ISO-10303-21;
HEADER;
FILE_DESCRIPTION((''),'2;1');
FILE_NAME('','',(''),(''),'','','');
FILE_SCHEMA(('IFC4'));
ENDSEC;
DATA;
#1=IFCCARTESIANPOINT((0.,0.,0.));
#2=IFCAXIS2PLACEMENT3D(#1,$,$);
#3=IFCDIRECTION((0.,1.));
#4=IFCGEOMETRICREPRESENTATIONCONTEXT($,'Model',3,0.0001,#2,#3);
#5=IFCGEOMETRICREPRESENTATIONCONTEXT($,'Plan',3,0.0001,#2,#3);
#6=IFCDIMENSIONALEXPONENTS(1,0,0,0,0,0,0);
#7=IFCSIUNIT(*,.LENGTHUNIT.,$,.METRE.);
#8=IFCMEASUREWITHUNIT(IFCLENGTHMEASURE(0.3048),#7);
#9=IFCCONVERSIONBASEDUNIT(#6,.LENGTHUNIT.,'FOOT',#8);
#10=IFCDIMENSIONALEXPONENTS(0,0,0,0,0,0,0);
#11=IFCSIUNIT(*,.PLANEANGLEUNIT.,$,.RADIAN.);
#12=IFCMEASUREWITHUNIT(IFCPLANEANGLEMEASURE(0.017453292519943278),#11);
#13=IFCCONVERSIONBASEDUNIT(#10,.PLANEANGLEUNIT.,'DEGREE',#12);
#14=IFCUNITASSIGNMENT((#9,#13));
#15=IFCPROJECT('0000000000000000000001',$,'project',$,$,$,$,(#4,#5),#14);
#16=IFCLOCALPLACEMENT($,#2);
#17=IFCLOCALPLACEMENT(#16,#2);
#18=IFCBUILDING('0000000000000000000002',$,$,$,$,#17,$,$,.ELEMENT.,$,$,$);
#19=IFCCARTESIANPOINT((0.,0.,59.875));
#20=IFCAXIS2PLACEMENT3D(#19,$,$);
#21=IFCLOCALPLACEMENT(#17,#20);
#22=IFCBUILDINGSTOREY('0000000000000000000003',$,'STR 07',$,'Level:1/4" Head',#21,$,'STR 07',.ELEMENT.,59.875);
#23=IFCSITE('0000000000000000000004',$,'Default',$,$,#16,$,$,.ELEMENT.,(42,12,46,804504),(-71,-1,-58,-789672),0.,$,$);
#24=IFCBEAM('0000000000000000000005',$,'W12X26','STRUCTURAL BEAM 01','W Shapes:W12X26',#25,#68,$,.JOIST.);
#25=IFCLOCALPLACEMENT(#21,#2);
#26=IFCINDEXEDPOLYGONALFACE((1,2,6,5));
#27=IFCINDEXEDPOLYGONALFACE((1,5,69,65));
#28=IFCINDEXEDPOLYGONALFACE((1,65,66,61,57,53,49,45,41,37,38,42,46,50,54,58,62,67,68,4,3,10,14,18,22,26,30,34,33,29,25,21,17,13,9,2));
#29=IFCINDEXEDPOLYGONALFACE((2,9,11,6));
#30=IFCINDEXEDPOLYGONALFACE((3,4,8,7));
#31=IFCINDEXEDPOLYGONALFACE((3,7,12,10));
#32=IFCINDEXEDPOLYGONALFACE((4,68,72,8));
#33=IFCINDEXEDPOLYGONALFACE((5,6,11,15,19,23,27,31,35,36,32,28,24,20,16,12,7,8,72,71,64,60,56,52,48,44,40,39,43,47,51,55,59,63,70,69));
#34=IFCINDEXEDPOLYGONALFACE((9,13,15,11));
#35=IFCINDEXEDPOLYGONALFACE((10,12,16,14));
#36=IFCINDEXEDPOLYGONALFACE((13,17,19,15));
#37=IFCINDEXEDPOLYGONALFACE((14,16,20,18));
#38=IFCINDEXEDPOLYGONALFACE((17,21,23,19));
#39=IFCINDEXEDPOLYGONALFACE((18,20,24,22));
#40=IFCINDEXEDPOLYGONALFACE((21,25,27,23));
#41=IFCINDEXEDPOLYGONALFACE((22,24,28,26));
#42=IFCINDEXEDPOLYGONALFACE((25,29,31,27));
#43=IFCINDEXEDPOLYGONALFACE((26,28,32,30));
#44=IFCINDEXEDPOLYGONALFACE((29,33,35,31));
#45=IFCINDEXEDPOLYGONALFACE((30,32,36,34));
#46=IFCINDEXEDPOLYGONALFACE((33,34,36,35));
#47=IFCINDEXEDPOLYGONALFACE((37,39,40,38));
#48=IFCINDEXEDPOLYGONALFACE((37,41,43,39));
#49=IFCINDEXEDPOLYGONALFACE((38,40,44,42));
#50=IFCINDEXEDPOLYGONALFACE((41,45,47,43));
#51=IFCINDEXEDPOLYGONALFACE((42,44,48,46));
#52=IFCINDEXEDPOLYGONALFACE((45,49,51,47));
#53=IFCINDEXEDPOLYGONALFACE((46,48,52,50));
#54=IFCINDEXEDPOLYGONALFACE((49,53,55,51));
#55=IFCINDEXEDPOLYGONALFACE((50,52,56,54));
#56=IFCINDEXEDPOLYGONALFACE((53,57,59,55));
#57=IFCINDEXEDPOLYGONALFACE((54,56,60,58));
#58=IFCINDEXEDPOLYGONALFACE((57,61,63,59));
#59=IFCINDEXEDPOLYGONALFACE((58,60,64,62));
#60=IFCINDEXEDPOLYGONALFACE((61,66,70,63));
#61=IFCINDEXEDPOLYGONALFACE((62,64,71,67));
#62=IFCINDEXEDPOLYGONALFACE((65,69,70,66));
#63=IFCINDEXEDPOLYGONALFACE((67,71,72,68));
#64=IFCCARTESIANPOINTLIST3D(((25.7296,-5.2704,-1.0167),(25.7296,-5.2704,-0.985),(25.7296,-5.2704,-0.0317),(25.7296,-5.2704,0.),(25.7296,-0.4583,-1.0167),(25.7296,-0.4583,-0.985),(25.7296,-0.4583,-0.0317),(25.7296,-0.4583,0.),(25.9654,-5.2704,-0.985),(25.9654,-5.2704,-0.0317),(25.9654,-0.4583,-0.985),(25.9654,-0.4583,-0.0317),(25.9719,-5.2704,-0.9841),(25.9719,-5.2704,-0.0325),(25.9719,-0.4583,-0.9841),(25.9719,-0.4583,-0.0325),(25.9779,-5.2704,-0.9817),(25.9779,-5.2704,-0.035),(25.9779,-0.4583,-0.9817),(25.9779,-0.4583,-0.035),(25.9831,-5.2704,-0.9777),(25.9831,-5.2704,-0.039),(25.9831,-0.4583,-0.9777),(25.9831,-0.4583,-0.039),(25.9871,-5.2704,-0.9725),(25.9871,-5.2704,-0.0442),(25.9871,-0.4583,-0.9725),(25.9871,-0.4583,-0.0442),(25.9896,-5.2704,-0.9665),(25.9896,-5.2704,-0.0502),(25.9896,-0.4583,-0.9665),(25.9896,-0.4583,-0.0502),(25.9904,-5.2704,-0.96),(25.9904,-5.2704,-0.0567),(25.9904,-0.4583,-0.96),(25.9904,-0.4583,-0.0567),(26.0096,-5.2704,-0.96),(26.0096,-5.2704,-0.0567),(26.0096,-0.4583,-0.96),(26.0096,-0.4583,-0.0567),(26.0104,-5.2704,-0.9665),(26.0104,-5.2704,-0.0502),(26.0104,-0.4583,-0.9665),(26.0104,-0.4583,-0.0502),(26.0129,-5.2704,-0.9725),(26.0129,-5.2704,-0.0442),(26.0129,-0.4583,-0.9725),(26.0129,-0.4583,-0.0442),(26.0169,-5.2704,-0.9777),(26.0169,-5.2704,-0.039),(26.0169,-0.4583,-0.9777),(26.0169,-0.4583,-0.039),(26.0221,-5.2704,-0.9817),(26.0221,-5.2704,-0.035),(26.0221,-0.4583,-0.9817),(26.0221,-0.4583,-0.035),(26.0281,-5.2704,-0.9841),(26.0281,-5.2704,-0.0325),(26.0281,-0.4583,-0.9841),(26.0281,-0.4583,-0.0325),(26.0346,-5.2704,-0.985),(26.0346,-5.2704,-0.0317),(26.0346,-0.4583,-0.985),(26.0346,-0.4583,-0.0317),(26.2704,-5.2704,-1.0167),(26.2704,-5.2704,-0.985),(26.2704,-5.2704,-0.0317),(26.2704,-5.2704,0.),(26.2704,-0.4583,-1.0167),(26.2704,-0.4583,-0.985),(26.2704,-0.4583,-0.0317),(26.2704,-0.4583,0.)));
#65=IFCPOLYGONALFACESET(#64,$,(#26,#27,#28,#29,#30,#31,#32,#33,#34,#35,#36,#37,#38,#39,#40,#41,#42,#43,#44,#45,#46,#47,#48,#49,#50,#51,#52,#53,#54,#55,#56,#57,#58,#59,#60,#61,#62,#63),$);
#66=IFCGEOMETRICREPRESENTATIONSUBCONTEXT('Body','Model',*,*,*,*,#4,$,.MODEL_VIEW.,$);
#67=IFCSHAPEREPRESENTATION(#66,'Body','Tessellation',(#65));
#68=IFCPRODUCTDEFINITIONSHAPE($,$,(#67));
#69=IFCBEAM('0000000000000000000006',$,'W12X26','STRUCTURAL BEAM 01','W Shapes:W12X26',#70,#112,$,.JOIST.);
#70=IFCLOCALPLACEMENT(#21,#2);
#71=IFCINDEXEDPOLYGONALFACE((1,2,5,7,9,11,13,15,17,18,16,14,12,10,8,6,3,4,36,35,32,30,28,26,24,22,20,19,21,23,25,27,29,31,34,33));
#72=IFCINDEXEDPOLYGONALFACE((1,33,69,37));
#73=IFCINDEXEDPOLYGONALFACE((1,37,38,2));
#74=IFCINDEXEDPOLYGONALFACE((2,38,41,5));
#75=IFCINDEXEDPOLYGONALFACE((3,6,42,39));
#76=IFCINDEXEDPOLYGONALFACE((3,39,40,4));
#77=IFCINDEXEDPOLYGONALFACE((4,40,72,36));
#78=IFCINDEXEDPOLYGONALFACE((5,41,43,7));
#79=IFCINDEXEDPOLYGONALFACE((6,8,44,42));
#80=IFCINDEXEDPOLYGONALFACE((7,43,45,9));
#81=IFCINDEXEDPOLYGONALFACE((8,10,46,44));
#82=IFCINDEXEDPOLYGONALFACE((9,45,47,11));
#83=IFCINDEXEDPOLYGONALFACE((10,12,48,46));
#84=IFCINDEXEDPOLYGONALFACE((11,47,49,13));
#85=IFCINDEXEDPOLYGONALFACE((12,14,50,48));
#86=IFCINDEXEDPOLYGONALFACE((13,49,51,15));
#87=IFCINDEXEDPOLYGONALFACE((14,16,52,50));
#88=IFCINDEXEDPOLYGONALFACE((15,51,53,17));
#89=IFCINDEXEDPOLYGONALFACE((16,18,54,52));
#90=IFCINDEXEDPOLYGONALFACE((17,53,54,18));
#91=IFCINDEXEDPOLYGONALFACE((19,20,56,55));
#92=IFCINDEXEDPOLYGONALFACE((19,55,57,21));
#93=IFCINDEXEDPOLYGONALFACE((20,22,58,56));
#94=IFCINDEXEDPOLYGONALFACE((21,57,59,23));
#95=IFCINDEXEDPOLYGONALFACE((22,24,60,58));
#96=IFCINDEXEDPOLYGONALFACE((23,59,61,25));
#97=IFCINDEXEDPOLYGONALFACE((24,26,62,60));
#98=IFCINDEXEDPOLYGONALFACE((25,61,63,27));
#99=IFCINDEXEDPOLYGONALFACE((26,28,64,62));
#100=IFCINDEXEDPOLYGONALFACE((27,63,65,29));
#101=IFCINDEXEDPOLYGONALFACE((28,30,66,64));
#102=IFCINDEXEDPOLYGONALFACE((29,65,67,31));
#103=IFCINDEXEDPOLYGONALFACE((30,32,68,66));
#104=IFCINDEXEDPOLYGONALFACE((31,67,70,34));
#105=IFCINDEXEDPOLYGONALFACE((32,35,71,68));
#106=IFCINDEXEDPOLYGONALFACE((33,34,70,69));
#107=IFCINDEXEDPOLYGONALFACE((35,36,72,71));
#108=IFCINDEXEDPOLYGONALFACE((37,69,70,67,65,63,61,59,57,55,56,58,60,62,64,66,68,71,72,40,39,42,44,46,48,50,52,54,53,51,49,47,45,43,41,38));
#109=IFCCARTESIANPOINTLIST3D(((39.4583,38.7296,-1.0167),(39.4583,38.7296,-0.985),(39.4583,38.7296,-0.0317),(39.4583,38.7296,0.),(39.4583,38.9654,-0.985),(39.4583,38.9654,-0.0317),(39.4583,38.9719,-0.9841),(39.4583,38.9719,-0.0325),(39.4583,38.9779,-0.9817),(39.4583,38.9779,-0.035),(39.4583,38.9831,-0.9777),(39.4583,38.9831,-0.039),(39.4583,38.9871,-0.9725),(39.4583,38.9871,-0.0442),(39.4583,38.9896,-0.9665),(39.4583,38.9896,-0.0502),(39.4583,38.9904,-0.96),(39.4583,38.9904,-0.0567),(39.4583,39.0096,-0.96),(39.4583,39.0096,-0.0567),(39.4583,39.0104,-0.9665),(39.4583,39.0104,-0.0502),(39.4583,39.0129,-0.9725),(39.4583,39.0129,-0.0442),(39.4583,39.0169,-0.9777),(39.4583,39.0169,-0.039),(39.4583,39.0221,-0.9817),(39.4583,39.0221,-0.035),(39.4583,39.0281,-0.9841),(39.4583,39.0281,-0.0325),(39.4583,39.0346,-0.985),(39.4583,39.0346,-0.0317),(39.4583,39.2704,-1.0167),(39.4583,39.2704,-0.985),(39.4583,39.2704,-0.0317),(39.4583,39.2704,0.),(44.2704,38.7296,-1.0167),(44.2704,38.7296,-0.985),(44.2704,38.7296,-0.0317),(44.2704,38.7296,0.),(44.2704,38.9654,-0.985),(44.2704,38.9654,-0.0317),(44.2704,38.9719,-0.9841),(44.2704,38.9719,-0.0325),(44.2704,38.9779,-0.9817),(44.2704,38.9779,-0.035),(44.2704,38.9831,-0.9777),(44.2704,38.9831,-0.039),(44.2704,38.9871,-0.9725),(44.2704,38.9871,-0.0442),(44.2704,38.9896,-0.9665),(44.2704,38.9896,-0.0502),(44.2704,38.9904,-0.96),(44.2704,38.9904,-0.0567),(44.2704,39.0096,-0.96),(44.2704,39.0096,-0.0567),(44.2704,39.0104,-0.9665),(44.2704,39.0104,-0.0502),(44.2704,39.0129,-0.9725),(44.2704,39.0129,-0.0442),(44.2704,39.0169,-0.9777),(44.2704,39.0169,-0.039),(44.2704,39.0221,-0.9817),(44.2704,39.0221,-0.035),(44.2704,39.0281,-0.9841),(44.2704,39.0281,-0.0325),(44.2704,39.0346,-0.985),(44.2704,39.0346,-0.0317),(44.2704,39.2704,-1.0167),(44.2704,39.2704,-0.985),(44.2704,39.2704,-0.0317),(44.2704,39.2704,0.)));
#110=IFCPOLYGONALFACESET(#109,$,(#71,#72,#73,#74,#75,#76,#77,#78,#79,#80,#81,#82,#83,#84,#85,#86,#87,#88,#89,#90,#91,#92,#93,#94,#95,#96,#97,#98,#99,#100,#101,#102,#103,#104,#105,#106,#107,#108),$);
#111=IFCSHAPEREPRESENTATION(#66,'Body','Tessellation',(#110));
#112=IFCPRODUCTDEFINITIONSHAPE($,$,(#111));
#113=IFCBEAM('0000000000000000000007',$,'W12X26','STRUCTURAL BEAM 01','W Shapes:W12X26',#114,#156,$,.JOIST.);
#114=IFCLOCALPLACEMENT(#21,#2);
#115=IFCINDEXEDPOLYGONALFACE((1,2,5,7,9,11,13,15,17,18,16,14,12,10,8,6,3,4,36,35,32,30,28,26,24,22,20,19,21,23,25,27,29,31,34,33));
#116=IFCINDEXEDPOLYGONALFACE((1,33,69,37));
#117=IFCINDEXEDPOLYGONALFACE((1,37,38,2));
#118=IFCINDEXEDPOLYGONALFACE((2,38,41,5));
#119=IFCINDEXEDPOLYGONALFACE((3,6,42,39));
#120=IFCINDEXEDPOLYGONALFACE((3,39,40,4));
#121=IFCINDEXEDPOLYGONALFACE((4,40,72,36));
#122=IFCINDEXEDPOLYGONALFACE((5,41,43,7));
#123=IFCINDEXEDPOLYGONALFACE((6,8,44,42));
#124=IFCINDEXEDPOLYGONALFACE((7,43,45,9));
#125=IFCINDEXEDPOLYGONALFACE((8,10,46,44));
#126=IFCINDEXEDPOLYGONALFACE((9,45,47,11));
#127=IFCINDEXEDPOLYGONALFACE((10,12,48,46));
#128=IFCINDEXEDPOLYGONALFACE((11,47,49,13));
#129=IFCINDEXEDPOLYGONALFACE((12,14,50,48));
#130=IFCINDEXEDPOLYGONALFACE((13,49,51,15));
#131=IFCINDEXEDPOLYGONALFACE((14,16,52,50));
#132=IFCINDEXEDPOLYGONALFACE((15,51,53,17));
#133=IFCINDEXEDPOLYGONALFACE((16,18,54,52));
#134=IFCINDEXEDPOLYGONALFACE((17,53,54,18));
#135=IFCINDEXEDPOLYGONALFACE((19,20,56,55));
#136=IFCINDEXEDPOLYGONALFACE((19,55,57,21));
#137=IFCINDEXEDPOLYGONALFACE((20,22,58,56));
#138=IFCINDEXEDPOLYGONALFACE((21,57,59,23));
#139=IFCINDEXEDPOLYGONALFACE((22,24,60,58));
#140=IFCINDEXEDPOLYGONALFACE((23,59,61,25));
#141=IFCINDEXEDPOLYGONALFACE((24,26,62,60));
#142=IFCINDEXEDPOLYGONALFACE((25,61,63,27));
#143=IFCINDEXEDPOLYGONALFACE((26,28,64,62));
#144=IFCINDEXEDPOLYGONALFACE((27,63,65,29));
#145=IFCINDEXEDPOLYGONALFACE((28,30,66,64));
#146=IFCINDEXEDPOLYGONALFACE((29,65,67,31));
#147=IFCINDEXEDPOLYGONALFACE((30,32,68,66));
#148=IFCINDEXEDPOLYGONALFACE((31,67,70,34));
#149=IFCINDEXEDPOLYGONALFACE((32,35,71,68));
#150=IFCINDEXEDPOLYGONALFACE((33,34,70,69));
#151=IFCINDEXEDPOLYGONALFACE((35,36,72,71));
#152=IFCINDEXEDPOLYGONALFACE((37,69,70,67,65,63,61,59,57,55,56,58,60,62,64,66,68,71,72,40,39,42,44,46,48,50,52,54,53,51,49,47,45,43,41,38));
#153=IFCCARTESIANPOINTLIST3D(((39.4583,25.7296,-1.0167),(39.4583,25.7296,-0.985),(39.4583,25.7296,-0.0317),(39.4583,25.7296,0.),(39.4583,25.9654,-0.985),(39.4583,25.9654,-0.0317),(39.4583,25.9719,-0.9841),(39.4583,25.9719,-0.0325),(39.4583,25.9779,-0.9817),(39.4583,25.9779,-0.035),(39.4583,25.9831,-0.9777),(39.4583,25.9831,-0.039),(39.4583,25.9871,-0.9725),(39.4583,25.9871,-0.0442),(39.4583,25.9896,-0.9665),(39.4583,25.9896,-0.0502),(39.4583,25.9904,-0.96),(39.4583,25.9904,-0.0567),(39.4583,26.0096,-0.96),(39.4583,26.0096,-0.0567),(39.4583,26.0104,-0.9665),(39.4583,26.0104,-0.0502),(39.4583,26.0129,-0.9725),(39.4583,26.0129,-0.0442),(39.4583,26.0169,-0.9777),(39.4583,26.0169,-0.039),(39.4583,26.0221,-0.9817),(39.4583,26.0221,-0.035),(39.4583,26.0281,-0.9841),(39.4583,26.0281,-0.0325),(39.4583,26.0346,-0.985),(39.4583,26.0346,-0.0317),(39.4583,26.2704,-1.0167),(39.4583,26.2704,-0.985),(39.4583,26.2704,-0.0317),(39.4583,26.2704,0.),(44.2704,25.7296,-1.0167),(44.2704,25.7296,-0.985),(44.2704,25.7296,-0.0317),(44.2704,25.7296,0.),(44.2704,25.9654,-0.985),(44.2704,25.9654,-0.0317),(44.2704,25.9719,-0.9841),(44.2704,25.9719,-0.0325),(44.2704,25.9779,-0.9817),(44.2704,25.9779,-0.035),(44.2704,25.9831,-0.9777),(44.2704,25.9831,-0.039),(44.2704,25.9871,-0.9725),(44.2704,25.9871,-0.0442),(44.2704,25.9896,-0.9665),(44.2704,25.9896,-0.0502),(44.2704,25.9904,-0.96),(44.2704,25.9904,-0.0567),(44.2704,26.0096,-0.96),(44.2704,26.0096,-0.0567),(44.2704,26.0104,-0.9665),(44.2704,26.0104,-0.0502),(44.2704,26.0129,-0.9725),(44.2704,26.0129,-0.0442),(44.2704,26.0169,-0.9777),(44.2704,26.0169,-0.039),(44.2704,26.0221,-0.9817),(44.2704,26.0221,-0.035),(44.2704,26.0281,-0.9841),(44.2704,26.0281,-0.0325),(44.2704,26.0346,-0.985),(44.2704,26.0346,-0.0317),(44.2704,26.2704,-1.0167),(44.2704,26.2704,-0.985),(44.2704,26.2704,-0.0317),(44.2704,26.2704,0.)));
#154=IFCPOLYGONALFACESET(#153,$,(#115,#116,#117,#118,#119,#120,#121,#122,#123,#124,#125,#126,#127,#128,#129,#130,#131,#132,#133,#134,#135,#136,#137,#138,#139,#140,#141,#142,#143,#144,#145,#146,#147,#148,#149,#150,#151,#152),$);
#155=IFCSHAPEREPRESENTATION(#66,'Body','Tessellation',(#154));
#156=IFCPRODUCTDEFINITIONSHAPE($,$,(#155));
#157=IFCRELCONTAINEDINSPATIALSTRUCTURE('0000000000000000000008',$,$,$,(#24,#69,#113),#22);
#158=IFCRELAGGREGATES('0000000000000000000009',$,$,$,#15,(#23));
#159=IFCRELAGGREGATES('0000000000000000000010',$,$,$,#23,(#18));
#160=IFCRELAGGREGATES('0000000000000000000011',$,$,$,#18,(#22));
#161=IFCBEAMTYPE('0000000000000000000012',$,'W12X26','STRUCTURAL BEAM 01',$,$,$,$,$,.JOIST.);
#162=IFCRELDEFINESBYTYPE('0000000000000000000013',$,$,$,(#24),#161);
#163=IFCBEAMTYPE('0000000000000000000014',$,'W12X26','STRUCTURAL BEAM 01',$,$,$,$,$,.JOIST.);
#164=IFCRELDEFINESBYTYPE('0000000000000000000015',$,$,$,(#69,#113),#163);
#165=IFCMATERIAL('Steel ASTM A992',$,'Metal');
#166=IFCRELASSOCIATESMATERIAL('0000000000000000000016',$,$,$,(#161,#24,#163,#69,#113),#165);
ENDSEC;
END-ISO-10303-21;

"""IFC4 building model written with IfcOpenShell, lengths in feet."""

from ifc_helpers import new_model, entity, si_unit, converted_unit, direction, frame, origin, place, context, subcontext, project, spatial, line, arc, indexed_curve, outline, extrude, source, transform, mapped, material, type_object, type_shapes, element, save


model = new_model("IFC4")

# Units and contexts
model_context = context("Model", 3, precision=0.0001, world=origin(), true_north=direction((0.0, 1.0)))
plan_context = context("Plan", 3, precision=0.0001, world=origin(), true_north=direction((0.0, 1.0)))
body_context = subcontext(model_context, "Body", "Model", "MODEL_VIEW")
ifc_project = project(units=[converted_unit("LENGTHUNIT", "FOOT", entity("IfcLengthMeasure", 0.3048), si_unit("LENGTHUNIT", "METRE"), dimensions=[1, 0, 0, 0, 0, 0, 0]), converted_unit("PLANEANGLEUNIT", "DEGREE", entity("IfcPlaneAngleMeasure", 0.017453292519943278), si_unit("PLANEANGLEUNIT", "RADIAN"), dimensions=[0, 0, 0, 0, 0, 0, 0])], contexts=[model_context, plan_context])

# Site, building, storey
site_placement = place(None, origin())
site = spatial("IfcSite", under=ifc_project, at=site_placement, Name="Default", CompositionType="ELEMENT", RefLatitude=(42, 12, 46, 804504), RefLongitude=(-71, -1, -58, -789672), RefElevation=0.0)
building_placement = place(site_placement, origin())
building = spatial("IfcBuilding", under=site, at=building_placement, CompositionType="ELEMENT")
storey_placement = place(building_placement, frame((0.0, 0.0, 59.875)))
storey = spatial("IfcBuildingStorey", under=building, at=storey_placement, Name="STR 07", ObjectType="Level:1/4\" Head", LongName="STR 07", CompositionType="ELEMENT", Elevation=59.875)

# Shared definitions
ifc_material = material(Name="Steel ASTM A992", Category="Metal")

# Beams
beam_type_1 = type_object("IfcBeamType", Name="W12X26", Description="STRUCTURAL BEAM 01", PredefinedType="JOIST", material=ifc_material)
shared_shape_1 = source(origin(), body_context, "Body", "SweptSolid", [
    extrude(outline(indexed_curve([(0.4767, -0.2704), (0.5083, -0.2704), (0.5083, 0.2704), (0.4767, 0.2704), (0.4767, 0.0346), (0.4693, 0.0169), (0.4517, 0.0096), (-0.4517, 0.0096), (-0.4693, 0.0169), (-0.4767, 0.0346), (-0.4767, 0.2704), (-0.5083, 0.2704), (-0.5083, -0.2704), (-0.4767, -0.2704), (-0.4767, -0.0346), (-0.4693, -0.0169), (-0.4517, -0.0096), (0.4517, -0.0096), (0.4693, -0.0169), (0.4767, -0.0346)], segments=[line(1, 2, 3, 4, 5), arc(5, 6, 7), line(7, 8), arc(8, 9, 10), line(10, 11, 12, 13, 14, 15), arc(15, 16, 17), line(17, 18), arc(18, 19, 20), line(20, 1)], self_intersect=False)), frame((-2.0417, 0.0, 0.0), z_axis=(1.0, 0.0, 0.0), x_axis=(0.0, 0.0, -1.0)), (0.0, 0.0, 1.0), 4.8121),
])
type_shapes(beam_type_1, [shared_shape_1])
for number, where, z_axis, x_axis, name in (
    (1, (26.0, -2.5, -0.5083), (0.0, 0.0, 1.0), (0.0, -1.0, 0.0), "W12X26"),
):
    element("IfcBeam", number, at=place(storey_placement, frame(where, z_axis=z_axis, x_axis=x_axis)), inside=storey, type_object=beam_type_1, material=ifc_material, Name=name, Description="STRUCTURAL BEAM 01", ObjectType="W Shapes:W12X26", PredefinedType="JOIST", context=body_context, shape_type="MappedRepresentation", body=[
        mapped(shared_shape_1, transform((0.0, 0.0, 0.0), scale=1.0)),
    ])
beam_type_2 = type_object("IfcBeamType", Name="W12X26", Description="STRUCTURAL BEAM 01", PredefinedType="JOIST", material=ifc_material)
shared_shape_2 = source(origin(), body_context, "Body", "SweptSolid", [
    extrude(outline(indexed_curve([(0.4767, -0.2704), (0.5083, -0.2704), (0.5083, 0.2704), (0.4767, 0.2704), (0.4767, 0.0346), (0.4693, 0.0169), (0.4517, 0.0096), (-0.4517, 0.0096), (-0.4693, 0.0169), (-0.4767, 0.0346), (-0.4767, 0.2704), (-0.5083, 0.2704), (-0.5083, -0.2704), (-0.4767, -0.2704), (-0.4767, -0.0346), (-0.4693, -0.0169), (-0.4517, -0.0096), (0.4517, -0.0096), (0.4693, -0.0169), (0.4767, -0.0346)], segments=[line(1, 2, 3, 4, 5), arc(5, 6, 7), line(7, 8), arc(8, 9, 10), line(10, 11, 12, 13, 14, 15), arc(15, 16, 17), line(17, 18), arc(18, 19, 20), line(20, 1)], self_intersect=False)), frame((-2.7704, 0.0, 0.0), z_axis=(1.0, 0.0, 0.0), x_axis=(0.0, 0.0, -1.0)), (0.0, 0.0, 1.0), 4.8121),
])
type_shapes(beam_type_2, [shared_shape_2])
for number, where, z_axis, x_axis, name in (
    (2, (41.5, 39.0, -0.5083), (0.0, 0.0, 1.0), (-1.0, 0.0, 0.0), "W12X26"),
    (3, (41.5, 26.0, -0.5083), (0.0, 0.0, 1.0), (-1.0, 0.0, 0.0), "W12X26"),
):
    element("IfcBeam", number, at=place(storey_placement, frame(where, z_axis=z_axis, x_axis=x_axis)), inside=storey, type_object=beam_type_2, material=ifc_material, Name=name, Description="STRUCTURAL BEAM 01", ObjectType="W Shapes:W12X26", PredefinedType="JOIST", context=body_context, shape_type="MappedRepresentation", body=[
        mapped(shared_shape_2, transform((0.0, 0.0, 0.0), scale=1.0)),
    ])

save(model, "model.ifc")
